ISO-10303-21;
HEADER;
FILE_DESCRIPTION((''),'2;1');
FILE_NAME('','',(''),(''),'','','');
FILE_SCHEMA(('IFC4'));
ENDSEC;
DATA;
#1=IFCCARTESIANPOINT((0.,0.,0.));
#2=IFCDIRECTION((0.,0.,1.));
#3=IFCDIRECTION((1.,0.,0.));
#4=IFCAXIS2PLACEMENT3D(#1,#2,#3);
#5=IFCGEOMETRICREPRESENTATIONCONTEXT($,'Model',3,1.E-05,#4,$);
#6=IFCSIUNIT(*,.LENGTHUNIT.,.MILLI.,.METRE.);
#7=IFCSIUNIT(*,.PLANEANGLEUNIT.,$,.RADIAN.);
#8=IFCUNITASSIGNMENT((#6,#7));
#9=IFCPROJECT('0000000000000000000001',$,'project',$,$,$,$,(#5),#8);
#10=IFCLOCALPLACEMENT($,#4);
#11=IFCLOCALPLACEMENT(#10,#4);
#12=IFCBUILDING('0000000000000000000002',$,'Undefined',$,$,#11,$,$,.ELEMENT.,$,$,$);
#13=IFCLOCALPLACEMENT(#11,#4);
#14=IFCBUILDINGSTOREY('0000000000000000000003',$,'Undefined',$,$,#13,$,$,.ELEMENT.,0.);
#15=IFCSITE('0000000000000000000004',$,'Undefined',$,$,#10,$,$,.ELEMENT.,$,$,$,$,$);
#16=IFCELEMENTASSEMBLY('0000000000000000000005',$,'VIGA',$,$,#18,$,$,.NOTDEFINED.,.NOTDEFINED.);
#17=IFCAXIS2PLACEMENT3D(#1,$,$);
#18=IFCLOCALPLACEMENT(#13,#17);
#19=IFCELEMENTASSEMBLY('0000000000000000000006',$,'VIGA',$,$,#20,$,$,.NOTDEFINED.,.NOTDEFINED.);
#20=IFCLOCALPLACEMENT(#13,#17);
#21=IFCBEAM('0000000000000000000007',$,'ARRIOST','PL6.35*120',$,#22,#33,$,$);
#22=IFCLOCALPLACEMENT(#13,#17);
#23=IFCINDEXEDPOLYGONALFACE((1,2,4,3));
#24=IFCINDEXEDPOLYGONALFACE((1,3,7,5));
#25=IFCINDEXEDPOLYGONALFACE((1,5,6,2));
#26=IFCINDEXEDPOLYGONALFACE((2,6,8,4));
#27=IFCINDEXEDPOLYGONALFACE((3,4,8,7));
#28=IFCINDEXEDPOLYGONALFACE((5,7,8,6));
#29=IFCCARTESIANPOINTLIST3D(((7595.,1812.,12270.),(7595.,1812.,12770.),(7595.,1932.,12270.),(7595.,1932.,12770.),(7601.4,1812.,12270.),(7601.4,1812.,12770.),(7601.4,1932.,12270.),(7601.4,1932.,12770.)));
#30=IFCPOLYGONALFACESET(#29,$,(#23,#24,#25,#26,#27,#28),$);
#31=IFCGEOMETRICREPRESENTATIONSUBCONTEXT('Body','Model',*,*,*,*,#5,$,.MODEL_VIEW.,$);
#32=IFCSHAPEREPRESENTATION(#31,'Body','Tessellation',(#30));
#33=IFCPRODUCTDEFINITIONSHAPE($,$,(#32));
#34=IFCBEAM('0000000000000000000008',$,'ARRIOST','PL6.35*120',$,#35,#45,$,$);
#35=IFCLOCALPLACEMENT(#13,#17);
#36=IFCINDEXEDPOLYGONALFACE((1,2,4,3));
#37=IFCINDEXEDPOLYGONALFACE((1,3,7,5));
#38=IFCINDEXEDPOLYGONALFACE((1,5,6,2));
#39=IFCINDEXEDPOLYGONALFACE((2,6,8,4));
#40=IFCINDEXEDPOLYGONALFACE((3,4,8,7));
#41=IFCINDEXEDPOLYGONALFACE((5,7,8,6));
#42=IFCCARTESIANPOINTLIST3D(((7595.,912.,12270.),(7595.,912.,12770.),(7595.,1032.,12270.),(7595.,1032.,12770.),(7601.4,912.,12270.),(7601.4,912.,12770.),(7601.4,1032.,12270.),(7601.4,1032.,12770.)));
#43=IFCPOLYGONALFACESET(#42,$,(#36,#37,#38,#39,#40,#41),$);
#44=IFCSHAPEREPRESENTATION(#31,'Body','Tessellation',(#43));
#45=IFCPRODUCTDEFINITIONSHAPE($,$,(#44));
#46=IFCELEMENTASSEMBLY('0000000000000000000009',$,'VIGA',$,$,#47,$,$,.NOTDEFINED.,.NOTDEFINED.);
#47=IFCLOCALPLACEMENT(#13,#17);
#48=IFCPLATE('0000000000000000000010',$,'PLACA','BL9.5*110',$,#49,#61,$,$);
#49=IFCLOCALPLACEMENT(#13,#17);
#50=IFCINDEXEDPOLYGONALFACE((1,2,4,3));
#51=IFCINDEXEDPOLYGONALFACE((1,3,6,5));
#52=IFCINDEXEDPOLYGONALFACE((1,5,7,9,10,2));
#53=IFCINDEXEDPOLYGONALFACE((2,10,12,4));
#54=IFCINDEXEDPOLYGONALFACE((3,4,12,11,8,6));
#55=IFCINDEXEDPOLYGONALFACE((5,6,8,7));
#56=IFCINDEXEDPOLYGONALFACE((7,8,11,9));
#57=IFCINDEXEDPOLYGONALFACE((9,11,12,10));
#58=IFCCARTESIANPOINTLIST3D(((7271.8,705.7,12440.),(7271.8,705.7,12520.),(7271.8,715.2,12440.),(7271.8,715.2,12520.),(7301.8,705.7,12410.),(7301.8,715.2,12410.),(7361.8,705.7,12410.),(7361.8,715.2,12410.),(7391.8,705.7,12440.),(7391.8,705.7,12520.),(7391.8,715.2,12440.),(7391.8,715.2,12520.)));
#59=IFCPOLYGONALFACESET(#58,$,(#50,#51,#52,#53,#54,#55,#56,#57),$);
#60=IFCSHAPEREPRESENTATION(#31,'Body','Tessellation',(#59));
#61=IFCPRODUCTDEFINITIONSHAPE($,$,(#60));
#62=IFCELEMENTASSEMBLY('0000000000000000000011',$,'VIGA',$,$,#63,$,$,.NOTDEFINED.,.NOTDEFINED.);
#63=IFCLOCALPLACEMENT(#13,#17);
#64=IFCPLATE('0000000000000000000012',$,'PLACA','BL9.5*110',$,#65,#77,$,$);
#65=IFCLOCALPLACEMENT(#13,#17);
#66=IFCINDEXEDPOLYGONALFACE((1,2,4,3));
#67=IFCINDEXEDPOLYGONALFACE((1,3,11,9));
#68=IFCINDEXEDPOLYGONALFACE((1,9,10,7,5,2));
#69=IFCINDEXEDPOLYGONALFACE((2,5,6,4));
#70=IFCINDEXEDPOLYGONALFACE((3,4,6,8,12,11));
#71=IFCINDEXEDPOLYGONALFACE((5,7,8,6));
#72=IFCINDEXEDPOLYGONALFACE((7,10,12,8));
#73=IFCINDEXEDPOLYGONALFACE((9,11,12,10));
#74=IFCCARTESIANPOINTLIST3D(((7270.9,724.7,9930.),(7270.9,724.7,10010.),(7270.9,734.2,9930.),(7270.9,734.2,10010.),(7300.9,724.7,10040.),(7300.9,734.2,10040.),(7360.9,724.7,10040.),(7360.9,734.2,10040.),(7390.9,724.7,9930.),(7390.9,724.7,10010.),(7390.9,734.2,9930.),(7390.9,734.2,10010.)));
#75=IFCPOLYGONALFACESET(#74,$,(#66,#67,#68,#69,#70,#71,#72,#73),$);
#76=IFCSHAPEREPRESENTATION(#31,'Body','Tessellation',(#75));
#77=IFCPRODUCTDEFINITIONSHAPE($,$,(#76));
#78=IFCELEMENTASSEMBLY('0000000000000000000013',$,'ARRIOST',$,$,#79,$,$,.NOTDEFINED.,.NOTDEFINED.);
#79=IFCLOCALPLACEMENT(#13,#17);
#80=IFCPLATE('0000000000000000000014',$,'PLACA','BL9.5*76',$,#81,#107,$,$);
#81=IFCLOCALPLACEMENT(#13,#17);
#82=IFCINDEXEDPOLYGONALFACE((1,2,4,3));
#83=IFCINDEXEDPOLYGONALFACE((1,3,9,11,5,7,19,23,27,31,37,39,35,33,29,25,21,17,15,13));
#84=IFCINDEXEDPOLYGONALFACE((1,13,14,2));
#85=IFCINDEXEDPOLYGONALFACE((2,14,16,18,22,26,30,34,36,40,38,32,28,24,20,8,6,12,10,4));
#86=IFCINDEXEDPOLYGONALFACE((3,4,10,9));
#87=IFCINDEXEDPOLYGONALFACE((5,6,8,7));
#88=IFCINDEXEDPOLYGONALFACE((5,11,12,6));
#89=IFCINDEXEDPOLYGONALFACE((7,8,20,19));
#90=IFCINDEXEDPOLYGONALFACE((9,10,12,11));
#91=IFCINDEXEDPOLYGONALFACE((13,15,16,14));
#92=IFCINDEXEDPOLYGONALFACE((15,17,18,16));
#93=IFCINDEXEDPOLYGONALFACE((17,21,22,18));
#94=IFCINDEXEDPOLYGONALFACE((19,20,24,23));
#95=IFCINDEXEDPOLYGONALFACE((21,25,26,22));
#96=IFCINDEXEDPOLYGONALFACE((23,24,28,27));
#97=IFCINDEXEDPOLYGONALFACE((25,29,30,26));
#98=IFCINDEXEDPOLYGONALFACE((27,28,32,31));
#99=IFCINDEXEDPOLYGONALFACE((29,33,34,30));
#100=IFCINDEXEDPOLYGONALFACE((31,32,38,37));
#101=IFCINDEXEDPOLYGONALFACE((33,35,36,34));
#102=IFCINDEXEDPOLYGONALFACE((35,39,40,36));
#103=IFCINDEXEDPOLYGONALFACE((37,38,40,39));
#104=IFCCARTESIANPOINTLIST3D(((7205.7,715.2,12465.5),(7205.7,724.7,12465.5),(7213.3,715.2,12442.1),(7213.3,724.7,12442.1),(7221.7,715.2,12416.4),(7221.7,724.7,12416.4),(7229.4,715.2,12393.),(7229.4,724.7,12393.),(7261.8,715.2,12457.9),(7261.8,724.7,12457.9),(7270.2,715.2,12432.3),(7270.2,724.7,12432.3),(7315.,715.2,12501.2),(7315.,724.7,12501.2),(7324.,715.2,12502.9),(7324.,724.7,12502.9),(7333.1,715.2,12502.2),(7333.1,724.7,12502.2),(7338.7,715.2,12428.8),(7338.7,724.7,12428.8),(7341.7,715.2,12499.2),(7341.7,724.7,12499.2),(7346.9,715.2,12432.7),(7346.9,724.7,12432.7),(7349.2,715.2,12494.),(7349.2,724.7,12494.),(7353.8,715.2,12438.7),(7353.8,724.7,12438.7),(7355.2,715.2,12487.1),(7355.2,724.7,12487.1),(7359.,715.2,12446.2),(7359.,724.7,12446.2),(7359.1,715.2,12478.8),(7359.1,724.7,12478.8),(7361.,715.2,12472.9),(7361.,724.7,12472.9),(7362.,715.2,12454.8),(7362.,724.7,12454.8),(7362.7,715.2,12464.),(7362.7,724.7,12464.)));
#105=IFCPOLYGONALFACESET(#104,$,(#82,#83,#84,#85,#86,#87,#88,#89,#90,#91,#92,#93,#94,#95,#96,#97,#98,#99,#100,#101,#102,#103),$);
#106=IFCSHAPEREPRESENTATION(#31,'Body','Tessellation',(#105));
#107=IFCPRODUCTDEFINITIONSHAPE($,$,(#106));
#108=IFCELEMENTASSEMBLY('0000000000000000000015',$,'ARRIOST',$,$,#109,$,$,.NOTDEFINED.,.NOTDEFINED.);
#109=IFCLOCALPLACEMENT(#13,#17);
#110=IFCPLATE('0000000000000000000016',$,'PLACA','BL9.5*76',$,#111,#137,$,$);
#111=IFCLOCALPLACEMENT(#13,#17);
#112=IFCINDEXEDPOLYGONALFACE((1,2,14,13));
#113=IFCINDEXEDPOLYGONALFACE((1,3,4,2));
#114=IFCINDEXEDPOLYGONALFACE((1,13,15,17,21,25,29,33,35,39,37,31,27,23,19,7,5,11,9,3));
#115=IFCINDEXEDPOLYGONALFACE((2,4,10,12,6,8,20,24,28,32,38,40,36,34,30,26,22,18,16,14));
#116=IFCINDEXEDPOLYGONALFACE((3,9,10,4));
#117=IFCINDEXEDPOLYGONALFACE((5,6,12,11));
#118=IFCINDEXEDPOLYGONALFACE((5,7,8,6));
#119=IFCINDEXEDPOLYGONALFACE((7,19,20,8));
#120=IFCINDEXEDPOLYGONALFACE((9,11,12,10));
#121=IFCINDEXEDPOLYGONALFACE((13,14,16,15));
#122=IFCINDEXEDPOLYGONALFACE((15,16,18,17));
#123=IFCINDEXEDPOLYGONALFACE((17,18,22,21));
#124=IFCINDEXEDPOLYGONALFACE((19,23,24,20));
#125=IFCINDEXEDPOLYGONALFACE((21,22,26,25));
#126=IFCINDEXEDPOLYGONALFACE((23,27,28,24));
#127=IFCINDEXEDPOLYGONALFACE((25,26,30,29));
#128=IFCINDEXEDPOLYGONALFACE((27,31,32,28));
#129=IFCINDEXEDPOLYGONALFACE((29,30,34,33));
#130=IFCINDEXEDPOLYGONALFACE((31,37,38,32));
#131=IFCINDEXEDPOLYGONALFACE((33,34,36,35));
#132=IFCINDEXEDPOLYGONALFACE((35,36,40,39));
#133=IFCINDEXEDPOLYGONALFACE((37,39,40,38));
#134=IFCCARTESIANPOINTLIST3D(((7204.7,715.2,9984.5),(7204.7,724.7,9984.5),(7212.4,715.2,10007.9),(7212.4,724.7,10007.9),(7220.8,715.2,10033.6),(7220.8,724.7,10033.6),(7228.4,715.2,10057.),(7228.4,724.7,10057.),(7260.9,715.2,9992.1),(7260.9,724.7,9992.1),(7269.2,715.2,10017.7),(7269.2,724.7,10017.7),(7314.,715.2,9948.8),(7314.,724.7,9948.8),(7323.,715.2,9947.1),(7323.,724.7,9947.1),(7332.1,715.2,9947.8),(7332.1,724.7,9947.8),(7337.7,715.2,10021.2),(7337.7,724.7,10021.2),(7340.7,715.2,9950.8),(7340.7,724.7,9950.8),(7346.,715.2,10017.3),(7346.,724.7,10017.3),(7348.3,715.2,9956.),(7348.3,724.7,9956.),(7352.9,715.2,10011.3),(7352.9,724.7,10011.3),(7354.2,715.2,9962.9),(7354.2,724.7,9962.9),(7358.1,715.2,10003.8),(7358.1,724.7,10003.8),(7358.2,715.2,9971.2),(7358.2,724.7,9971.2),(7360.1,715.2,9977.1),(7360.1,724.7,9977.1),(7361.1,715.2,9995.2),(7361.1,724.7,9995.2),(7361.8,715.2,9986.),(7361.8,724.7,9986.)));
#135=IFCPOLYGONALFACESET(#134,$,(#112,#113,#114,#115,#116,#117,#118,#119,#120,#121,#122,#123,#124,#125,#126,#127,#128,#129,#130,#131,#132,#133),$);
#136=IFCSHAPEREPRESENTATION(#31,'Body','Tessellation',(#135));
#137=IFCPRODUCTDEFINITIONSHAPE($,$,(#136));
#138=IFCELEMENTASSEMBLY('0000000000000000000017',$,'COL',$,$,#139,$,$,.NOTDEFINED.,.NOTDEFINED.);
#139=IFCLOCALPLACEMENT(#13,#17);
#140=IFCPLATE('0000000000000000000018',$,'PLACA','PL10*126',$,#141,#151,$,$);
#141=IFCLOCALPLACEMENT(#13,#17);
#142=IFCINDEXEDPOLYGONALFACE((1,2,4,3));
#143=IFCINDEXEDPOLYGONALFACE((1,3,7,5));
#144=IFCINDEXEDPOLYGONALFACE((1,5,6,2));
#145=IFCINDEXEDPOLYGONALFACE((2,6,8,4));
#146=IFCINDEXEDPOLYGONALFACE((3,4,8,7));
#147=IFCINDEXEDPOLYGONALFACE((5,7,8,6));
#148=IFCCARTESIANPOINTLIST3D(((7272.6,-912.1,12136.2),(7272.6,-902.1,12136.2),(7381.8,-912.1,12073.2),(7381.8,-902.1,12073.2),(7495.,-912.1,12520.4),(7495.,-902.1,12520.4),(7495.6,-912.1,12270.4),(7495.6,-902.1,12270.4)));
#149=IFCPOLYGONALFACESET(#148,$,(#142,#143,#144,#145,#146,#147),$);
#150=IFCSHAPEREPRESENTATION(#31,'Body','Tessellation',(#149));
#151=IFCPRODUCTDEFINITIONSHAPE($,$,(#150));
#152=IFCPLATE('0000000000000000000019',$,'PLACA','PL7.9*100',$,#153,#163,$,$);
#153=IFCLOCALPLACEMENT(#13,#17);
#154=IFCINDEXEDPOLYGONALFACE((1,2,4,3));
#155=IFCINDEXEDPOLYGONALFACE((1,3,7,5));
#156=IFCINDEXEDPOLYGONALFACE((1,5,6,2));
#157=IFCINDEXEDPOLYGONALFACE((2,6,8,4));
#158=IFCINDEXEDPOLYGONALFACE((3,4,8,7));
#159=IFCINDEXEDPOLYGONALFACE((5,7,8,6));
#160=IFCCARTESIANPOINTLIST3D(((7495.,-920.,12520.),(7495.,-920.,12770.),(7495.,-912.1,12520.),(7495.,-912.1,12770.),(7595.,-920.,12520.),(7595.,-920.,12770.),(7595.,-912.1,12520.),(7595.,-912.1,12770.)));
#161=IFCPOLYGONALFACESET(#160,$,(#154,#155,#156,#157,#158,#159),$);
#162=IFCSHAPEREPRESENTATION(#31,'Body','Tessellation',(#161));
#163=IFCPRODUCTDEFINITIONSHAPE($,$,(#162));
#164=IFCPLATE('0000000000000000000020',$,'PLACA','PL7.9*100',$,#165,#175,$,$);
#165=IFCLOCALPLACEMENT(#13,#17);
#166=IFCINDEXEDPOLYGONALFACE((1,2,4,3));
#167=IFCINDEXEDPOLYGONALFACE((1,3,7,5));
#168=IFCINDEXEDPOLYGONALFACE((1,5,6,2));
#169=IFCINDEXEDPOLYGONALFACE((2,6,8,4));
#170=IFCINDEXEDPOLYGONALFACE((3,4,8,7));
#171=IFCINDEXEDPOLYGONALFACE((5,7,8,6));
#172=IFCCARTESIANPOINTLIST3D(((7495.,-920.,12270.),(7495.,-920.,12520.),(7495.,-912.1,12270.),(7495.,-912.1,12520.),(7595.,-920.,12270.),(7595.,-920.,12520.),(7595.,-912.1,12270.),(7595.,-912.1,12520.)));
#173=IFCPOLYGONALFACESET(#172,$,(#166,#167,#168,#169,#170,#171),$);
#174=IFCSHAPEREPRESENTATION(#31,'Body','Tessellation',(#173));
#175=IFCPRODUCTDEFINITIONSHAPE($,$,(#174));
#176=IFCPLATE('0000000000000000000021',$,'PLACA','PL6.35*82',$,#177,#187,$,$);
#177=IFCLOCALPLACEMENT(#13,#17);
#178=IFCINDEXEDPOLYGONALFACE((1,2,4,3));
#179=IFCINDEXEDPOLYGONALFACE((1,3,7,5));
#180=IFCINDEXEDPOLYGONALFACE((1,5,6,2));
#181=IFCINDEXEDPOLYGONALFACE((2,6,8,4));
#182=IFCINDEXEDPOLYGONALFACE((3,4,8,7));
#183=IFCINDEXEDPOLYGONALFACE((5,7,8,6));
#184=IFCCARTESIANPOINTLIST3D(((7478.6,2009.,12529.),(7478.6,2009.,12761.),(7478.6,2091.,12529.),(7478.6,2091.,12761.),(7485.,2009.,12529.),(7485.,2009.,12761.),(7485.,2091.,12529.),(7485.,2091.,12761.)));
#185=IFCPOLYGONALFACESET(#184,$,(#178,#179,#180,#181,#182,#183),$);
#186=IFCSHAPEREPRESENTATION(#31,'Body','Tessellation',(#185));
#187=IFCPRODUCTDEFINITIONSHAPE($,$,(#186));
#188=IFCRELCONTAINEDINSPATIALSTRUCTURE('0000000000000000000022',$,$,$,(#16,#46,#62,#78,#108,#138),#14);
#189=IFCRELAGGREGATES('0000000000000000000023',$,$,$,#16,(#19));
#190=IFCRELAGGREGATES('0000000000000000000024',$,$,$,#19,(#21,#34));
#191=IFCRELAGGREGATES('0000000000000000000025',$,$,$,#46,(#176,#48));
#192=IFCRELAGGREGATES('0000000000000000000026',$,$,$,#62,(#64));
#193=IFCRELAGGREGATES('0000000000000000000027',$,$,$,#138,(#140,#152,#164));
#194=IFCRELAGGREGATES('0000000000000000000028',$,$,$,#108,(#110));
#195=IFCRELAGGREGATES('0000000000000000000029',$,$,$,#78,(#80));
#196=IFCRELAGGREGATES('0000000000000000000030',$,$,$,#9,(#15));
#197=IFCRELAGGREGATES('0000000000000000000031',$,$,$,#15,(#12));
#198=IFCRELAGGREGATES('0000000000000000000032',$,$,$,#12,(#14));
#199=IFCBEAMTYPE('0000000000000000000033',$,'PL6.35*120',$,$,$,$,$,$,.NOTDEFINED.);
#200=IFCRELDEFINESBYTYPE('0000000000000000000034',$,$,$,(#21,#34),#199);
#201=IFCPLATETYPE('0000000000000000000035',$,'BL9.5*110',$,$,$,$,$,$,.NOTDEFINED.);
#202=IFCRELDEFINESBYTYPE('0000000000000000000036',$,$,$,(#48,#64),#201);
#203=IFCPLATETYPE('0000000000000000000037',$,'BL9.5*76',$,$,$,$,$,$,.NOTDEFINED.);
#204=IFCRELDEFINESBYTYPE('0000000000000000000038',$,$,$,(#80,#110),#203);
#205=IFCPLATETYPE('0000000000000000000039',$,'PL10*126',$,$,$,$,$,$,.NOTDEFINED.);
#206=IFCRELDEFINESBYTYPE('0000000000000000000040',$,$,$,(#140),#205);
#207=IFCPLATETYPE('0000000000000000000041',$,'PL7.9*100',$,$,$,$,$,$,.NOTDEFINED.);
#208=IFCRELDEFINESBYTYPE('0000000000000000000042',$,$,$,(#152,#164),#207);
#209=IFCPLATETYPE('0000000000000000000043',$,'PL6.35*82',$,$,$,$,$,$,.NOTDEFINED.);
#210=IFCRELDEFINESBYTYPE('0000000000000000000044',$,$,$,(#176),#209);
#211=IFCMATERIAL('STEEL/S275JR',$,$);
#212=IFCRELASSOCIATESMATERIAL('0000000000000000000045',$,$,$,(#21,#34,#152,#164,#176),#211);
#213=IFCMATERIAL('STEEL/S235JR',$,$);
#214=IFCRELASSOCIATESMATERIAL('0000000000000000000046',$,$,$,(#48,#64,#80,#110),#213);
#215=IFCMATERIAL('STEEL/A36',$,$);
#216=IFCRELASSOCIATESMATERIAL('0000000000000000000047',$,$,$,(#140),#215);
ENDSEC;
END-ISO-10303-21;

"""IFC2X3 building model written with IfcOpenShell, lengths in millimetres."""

from ifc_helpers import new_model, si_unit, frame, frame_2d, origin_with_axes, origin_2d_with_axis, place, context, subcontext, project, spatial, polyline, circle_curve, parameter, trimmed, segment, composite_curve, rectangle, outline, extrude, boolean, material, type_object, element, aggregate, save


model = new_model("IFC2X3")

# Units and contexts
model_context = context("Model", 3, precision=1e-05, world=origin_with_axes())
body_context = subcontext(model_context, "Body", "Model", "MODEL_VIEW")
ifc_project = project(units=[si_unit("LENGTHUNIT", "METRE", prefix="MILLI"), si_unit("PLANEANGLEUNIT", "RADIAN")], contexts=[model_context])

# Site, building, storey
site_placement = place(None, origin_with_axes())
site = spatial("IfcSite", under=ifc_project, at=site_placement, Name="Undefined", CompositionType="ELEMENT")
building_placement = place(site_placement, origin_with_axes())
building = spatial("IfcBuilding", under=site, at=building_placement, Name="Undefined", CompositionType="ELEMENT")
storey_placement = place(building_placement, origin_with_axes())
storey = spatial("IfcBuildingStorey", under=building, at=storey_placement, Name="Undefined", CompositionType="ELEMENT", Elevation=0.0)

# Element assemblies, beams
assembly_1_placement = place(storey_placement, origin_with_axes())
assembly_1 = element("IfcElementAssembly", 1, at=assembly_1_placement, inside=storey, Name="VIGA", AssemblyPlace="NOTDEFINED", PredefinedType="NOTDEFINED")
assembly_2_placement = place(assembly_1_placement, origin_with_axes())
assembly_2 = element("IfcElementAssembly", 2, at=assembly_2_placement, Name="VIGA", AssemblyPlace="NOTDEFINED", PredefinedType="NOTDEFINED")
aggregate(assembly_1, [assembly_2])
ifc_material_1 = material(Name="STEEL/S275JR")
beam_type = type_object("IfcBeamType", Name="PL6.35*120", PredefinedType="NOTDEFINED")
beam_1_placement = place(assembly_2_placement, frame((7598.2, 1872.0, 12270.0), z_axis=(0.0, 1.0, 0.0), x_axis=(0.0, 0.0, 1.0)))
beam_1 = element("IfcBeam", 3, at=beam_1_placement, type_object=beam_type, material=ifc_material_1, Name="ARRIOST", Description="PL6.35*120", context=body_context, shape_type="SweptSolid", body=[
    extrude(rectangle(XDim=6.3, YDim=120.0, at=origin_2d_with_axis()), frame((500.0, 0.0, 0.0), z_axis=(-1.0, 0.0, 0.0), x_axis=(0.0, -1.0, 0.0)), (0.0, 0.0, 1.0), 500.0),
])
beam_2_placement = place(assembly_2_placement, frame((7598.2, 972.0, 12270.0), z_axis=(0.0, 1.0, 0.0), x_axis=(0.0, 0.0, 1.0)))
beam_2 = element("IfcBeam", 4, at=beam_2_placement, type_object=beam_type, material=ifc_material_1, Name="ARRIOST", Description="PL6.35*120", context=body_context, shape_type="SweptSolid", body=[
    extrude(rectangle(XDim=6.3, YDim=120.0, at=origin_2d_with_axis()), frame((500.0, 0.0, 0.0), z_axis=(-1.0, 0.0, 0.0), x_axis=(0.0, -1.0, 0.0)), (0.0, 0.0, 1.0), 500.0),
])
aggregate(assembly_2, [beam_1, beam_2])

# Element assemblies, plates
assembly_3_placement = place(storey_placement, origin_with_axes())
assembly_3 = element("IfcElementAssembly", 5, at=assembly_3_placement, inside=storey, Name="VIGA", AssemblyPlace="NOTDEFINED", PredefinedType="NOTDEFINED")
ifc_material_2 = material(Name="STEEL/S235JR")
plate_type_1 = type_object("IfcPlateType", Name="BL9.5*110", PredefinedType="NOTDEFINED")
plate_1_placement = place(assembly_3_placement, frame((7271.8, 710.5, 12440.0), z_axis=(0.0, 1.0, 0.0), x_axis=(0.0, 0.0, 1.0)))
plate_1 = element("IfcPlate", 6, at=plate_1_placement, type_object=plate_type_1, material=ifc_material_2, Name="PLACA", Description="BL9.5*110", context=body_context, shape_type="SweptSolid", body=[
    extrude(outline(polyline([(0.0, 0.0), (80.0, 0.0), (80.0, 120.0), (0.0, 120.0), (-30.0, 90.0), (-30.0, 30.0), (0.0, 0.0)])), frame((0.0, 0.0, -4.7), z_axis=(0.0, 0.0, 1.0), x_axis=(1.0, 0.0, 0.0)), (0.0, 0.0, 1.0), 9.5),
])
assembly_4_placement = place(storey_placement, origin_with_axes())
assembly_4 = element("IfcElementAssembly", 7, at=assembly_4_placement, inside=storey, Name="VIGA", AssemblyPlace="NOTDEFINED", PredefinedType="NOTDEFINED")
plate_2_placement = place(assembly_4_placement, frame((7270.9, 729.5, 10010.0), z_axis=(0.0, -1.0, 0.0), x_axis=(0.0, 0.0, -1.0)))
plate_2 = element("IfcPlate", 8, at=plate_2_placement, type_object=plate_type_1, material=ifc_material_2, Name="PLACA", Description="BL9.5*110", context=body_context, shape_type="SweptSolid", body=[
    extrude(outline(polyline([(0.0, 0.0), (80.0, 0.0), (80.0, 120.0), (0.0, 120.0), (-30.0, 90.0), (-30.0, 30.0), (0.0, 0.0)])), frame((0.0, 0.0, -4.7), z_axis=(0.0, 0.0, 1.0), x_axis=(1.0, 0.0, 0.0)), (0.0, 0.0, 1.0), 9.5),
])
assembly_5_placement = place(storey_placement, origin_with_axes())
assembly_5 = element("IfcElementAssembly", 9, at=assembly_5_placement, inside=storey, Name="ARRIOST", AssemblyPlace="NOTDEFINED", PredefinedType="NOTDEFINED")
plate_type_2 = type_object("IfcPlateType", Name="BL9.5*76", PredefinedType="NOTDEFINED")
plate_3_placement = place(assembly_5_placement, frame((7348.2, 720.0, 12512.1), z_axis=(0.0, 1.0, 0.0), x_axis=(0.310822, 0.0, -0.950468)))
plate_3 = element("IfcPlate", 10, at=plate_3_placement, type_object=plate_type_2, material=ifc_material_2, Name="PLACA", Description="BL9.5*76", context=body_context, shape_type="CSG", body=[
    boolean("DIFFERENCE", extrude(outline(composite_curve([segment(trimmed(circle_curve(frame_2d((35.0, 35.0), x_axis=(-1.0, 0.0)), 35.0), [parameter(0.0)], [parameter(1.570796)], True, "PARAMETER"), True, "CONTINUOUS"), segment(polyline([(35.0, 0.0), (41.2, 0.0)]), True, "CONTINUOUS"), segment(trimmed(circle_curve(frame_2d((41.2, 35.0), x_axis=(0.0, -1.0)), 35.0), [parameter(0.0)], [parameter(1.570796)], True, "PARAMETER"), True, "CONTINUOUS"), segment(polyline([(76.2, 35.0), (76.2, 150.0), (0.0, 150.0), (0.0, 35.0)]), True, "CONTINUOUS")], self_intersect=True)), frame((0.0, 0.0, -4.7), z_axis=(0.0, 0.0, 1.0), x_axis=(1.0, 0.0, 0.0)), (0.0, 0.0, 1.0), 9.5), extrude(rectangle(XDim=27.0, YDim=27.0, at=origin_2d_with_axis()), frame((38.1, 250.0, 0.0), z_axis=(0.0, -1.0, 0.0), x_axis=(-1.0, 0.0, 0.0)), (0.0, 0.0, 1.0), 151.0)),
])
assembly_6_placement = place(storey_placement, origin_with_axes())
assembly_6 = element("IfcElementAssembly", 11, at=assembly_6_placement, inside=storey, Name="ARRIOST", AssemblyPlace="NOTDEFINED", PredefinedType="NOTDEFINED")
plate_4_placement = place(assembly_6_placement, frame((7347.3, 720.0, 9937.9), z_axis=(0.0, -1.0, 0.0), x_axis=(0.310857, 0.0, 0.950457)))
plate_4 = element("IfcPlate", 12, at=plate_4_placement, type_object=plate_type_2, material=ifc_material_2, Name="PLACA", Description="BL9.5*76", context=body_context, shape_type="CSG", body=[
    boolean("DIFFERENCE", extrude(outline(composite_curve([segment(trimmed(circle_curve(frame_2d((35.0, 35.0), x_axis=(-1.0, 0.0)), 35.0), [parameter(0.0)], [parameter(1.570796)], True, "PARAMETER"), True, "CONTINUOUS"), segment(polyline([(35.0, 0.0), (41.2, 0.0)]), True, "CONTINUOUS"), segment(trimmed(circle_curve(frame_2d((41.2, 35.0), x_axis=(0.0, -1.0)), 35.0), [parameter(0.0)], [parameter(1.570796)], True, "PARAMETER"), True, "CONTINUOUS"), segment(polyline([(76.2, 35.0), (76.2, 150.0), (0.0, 150.0), (0.0, 35.0)]), True, "CONTINUOUS")], self_intersect=True)), frame((0.0, 0.0, -4.7), z_axis=(0.0, 0.0, 1.0), x_axis=(1.0, 0.0, 0.0)), (0.0, 0.0, 1.0), 9.5), extrude(rectangle(XDim=27.0, YDim=27.0, at=origin_2d_with_axis()), frame((38.1, 250.0, 0.0), z_axis=(0.0, -1.0, 0.0), x_axis=(1.0, 0.0, 0.0)), (0.0, 0.0, 1.0), 151.0)),
])

# Element assembly, plates
assembly_7_placement = place(storey_placement, origin_with_axes())
assembly_7 = element("IfcElementAssembly", 13, at=assembly_7_placement, inside=storey, Name="COL", AssemblyPlace="NOTDEFINED", PredefinedType="NOTDEFINED")
ifc_material_3 = material(Name="STEEL/A36")
plate_type_3 = type_object("IfcPlateType", Name="PL10*126", PredefinedType="NOTDEFINED")
plate_5_placement = place(assembly_7_placement, frame((7495.0, -907.1, 12520.4), z_axis=(0.0, -1.0, 0.0), x_axis=(-0.500975, 0.0, -0.865462)))
plate_5 = element("IfcPlate", 14, at=plate_5_placement, type_object=plate_type_3, material=ifc_material_3, Name="PLACA", Description="PL10*126", context=body_context, shape_type="SweptSolid", body=[
    extrude(outline(polyline([(0.0, 0.0), (443.9, 0.0), (443.7, 126.0), (216.1, 125.7), (0.0, 0.0)])), frame((0.0, 0.0, -5.0), z_axis=(0.0, 0.0, 1.0), x_axis=(1.0, 0.0, 0.0)), (0.0, 0.0, 1.0), 10.0),
])
plate_type_4 = type_object("IfcPlateType", Name="PL7.9*100", PredefinedType="NOTDEFINED")
plate_6_placement = place(assembly_7_placement, frame((7495.0, -916.0, 12520.0), z_axis=(0.0, 1.0, 0.0), x_axis=(0.0, 0.0, 1.0)))
plate_6 = element("IfcPlate", 15, at=plate_6_placement, type_object=plate_type_4, material=ifc_material_1, Name="PLACA", Description="PL7.9*100", context=body_context, shape_type="SweptSolid", body=[
    extrude(outline(polyline([(0.0, 0.0), (250.0, 0.0), (250.0, 100.0), (0.0, 100.0), (0.0, 0.0)])), frame((0.0, 0.0, -4.0), z_axis=(0.0, 0.0, 1.0), x_axis=(1.0, 0.0, 0.0)), (0.0, 0.0, 1.0), 7.9),
])
plate_7_placement = place(assembly_7_placement, frame((7495.0, -916.0, 12270.0), z_axis=(0.0, 1.0, 0.0), x_axis=(0.0, 0.0, 1.0)))
plate_7 = element("IfcPlate", 16, at=plate_7_placement, type_object=plate_type_4, material=ifc_material_1, Name="PLACA", Description="PL7.9*100", context=body_context, shape_type="SweptSolid", body=[
    extrude(outline(polyline([(0.0, 0.0), (250.0, 0.0), (250.0, 100.0), (0.0, 100.0), (0.0, 0.0)])), frame((0.0, 0.0, -4.0), z_axis=(0.0, 0.0, 1.0), x_axis=(1.0, 0.0, 0.0)), (0.0, 0.0, 1.0), 7.9),
])

# Plate
plate_type_5 = type_object("IfcPlateType", Name="PL6.35*82", PredefinedType="NOTDEFINED")
plate_8_placement = place(assembly_3_placement, frame((7481.8, 2009.0, 12761.0), z_axis=(-1.0, 0.0, 0.0), x_axis=(0.0, 1.0, 0.0)))
plate_8 = element("IfcPlate", 17, at=plate_8_placement, type_object=plate_type_5, material=ifc_material_1, Name="PLACA", Description="PL6.35*82", context=body_context, shape_type="SweptSolid", body=[
    extrude(outline(polyline([(0.0, 0.0), (82.0, 0.0), (82.0, 232.0), (0.0, 232.0), (0.0, 0.0)])), frame((0.0, 0.0, -3.2), z_axis=(0.0, 0.0, 1.0), x_axis=(1.0, 0.0, 0.0)), (0.0, 0.0, 1.0), 6.4),
])
aggregate(assembly_3, [plate_8, plate_1])

aggregate(assembly_4, [plate_2])

aggregate(assembly_7, [plate_5, plate_6, plate_7])

aggregate(assembly_6, [plate_4])
aggregate(assembly_5, [plate_3])

save(model, "model.ifc")
